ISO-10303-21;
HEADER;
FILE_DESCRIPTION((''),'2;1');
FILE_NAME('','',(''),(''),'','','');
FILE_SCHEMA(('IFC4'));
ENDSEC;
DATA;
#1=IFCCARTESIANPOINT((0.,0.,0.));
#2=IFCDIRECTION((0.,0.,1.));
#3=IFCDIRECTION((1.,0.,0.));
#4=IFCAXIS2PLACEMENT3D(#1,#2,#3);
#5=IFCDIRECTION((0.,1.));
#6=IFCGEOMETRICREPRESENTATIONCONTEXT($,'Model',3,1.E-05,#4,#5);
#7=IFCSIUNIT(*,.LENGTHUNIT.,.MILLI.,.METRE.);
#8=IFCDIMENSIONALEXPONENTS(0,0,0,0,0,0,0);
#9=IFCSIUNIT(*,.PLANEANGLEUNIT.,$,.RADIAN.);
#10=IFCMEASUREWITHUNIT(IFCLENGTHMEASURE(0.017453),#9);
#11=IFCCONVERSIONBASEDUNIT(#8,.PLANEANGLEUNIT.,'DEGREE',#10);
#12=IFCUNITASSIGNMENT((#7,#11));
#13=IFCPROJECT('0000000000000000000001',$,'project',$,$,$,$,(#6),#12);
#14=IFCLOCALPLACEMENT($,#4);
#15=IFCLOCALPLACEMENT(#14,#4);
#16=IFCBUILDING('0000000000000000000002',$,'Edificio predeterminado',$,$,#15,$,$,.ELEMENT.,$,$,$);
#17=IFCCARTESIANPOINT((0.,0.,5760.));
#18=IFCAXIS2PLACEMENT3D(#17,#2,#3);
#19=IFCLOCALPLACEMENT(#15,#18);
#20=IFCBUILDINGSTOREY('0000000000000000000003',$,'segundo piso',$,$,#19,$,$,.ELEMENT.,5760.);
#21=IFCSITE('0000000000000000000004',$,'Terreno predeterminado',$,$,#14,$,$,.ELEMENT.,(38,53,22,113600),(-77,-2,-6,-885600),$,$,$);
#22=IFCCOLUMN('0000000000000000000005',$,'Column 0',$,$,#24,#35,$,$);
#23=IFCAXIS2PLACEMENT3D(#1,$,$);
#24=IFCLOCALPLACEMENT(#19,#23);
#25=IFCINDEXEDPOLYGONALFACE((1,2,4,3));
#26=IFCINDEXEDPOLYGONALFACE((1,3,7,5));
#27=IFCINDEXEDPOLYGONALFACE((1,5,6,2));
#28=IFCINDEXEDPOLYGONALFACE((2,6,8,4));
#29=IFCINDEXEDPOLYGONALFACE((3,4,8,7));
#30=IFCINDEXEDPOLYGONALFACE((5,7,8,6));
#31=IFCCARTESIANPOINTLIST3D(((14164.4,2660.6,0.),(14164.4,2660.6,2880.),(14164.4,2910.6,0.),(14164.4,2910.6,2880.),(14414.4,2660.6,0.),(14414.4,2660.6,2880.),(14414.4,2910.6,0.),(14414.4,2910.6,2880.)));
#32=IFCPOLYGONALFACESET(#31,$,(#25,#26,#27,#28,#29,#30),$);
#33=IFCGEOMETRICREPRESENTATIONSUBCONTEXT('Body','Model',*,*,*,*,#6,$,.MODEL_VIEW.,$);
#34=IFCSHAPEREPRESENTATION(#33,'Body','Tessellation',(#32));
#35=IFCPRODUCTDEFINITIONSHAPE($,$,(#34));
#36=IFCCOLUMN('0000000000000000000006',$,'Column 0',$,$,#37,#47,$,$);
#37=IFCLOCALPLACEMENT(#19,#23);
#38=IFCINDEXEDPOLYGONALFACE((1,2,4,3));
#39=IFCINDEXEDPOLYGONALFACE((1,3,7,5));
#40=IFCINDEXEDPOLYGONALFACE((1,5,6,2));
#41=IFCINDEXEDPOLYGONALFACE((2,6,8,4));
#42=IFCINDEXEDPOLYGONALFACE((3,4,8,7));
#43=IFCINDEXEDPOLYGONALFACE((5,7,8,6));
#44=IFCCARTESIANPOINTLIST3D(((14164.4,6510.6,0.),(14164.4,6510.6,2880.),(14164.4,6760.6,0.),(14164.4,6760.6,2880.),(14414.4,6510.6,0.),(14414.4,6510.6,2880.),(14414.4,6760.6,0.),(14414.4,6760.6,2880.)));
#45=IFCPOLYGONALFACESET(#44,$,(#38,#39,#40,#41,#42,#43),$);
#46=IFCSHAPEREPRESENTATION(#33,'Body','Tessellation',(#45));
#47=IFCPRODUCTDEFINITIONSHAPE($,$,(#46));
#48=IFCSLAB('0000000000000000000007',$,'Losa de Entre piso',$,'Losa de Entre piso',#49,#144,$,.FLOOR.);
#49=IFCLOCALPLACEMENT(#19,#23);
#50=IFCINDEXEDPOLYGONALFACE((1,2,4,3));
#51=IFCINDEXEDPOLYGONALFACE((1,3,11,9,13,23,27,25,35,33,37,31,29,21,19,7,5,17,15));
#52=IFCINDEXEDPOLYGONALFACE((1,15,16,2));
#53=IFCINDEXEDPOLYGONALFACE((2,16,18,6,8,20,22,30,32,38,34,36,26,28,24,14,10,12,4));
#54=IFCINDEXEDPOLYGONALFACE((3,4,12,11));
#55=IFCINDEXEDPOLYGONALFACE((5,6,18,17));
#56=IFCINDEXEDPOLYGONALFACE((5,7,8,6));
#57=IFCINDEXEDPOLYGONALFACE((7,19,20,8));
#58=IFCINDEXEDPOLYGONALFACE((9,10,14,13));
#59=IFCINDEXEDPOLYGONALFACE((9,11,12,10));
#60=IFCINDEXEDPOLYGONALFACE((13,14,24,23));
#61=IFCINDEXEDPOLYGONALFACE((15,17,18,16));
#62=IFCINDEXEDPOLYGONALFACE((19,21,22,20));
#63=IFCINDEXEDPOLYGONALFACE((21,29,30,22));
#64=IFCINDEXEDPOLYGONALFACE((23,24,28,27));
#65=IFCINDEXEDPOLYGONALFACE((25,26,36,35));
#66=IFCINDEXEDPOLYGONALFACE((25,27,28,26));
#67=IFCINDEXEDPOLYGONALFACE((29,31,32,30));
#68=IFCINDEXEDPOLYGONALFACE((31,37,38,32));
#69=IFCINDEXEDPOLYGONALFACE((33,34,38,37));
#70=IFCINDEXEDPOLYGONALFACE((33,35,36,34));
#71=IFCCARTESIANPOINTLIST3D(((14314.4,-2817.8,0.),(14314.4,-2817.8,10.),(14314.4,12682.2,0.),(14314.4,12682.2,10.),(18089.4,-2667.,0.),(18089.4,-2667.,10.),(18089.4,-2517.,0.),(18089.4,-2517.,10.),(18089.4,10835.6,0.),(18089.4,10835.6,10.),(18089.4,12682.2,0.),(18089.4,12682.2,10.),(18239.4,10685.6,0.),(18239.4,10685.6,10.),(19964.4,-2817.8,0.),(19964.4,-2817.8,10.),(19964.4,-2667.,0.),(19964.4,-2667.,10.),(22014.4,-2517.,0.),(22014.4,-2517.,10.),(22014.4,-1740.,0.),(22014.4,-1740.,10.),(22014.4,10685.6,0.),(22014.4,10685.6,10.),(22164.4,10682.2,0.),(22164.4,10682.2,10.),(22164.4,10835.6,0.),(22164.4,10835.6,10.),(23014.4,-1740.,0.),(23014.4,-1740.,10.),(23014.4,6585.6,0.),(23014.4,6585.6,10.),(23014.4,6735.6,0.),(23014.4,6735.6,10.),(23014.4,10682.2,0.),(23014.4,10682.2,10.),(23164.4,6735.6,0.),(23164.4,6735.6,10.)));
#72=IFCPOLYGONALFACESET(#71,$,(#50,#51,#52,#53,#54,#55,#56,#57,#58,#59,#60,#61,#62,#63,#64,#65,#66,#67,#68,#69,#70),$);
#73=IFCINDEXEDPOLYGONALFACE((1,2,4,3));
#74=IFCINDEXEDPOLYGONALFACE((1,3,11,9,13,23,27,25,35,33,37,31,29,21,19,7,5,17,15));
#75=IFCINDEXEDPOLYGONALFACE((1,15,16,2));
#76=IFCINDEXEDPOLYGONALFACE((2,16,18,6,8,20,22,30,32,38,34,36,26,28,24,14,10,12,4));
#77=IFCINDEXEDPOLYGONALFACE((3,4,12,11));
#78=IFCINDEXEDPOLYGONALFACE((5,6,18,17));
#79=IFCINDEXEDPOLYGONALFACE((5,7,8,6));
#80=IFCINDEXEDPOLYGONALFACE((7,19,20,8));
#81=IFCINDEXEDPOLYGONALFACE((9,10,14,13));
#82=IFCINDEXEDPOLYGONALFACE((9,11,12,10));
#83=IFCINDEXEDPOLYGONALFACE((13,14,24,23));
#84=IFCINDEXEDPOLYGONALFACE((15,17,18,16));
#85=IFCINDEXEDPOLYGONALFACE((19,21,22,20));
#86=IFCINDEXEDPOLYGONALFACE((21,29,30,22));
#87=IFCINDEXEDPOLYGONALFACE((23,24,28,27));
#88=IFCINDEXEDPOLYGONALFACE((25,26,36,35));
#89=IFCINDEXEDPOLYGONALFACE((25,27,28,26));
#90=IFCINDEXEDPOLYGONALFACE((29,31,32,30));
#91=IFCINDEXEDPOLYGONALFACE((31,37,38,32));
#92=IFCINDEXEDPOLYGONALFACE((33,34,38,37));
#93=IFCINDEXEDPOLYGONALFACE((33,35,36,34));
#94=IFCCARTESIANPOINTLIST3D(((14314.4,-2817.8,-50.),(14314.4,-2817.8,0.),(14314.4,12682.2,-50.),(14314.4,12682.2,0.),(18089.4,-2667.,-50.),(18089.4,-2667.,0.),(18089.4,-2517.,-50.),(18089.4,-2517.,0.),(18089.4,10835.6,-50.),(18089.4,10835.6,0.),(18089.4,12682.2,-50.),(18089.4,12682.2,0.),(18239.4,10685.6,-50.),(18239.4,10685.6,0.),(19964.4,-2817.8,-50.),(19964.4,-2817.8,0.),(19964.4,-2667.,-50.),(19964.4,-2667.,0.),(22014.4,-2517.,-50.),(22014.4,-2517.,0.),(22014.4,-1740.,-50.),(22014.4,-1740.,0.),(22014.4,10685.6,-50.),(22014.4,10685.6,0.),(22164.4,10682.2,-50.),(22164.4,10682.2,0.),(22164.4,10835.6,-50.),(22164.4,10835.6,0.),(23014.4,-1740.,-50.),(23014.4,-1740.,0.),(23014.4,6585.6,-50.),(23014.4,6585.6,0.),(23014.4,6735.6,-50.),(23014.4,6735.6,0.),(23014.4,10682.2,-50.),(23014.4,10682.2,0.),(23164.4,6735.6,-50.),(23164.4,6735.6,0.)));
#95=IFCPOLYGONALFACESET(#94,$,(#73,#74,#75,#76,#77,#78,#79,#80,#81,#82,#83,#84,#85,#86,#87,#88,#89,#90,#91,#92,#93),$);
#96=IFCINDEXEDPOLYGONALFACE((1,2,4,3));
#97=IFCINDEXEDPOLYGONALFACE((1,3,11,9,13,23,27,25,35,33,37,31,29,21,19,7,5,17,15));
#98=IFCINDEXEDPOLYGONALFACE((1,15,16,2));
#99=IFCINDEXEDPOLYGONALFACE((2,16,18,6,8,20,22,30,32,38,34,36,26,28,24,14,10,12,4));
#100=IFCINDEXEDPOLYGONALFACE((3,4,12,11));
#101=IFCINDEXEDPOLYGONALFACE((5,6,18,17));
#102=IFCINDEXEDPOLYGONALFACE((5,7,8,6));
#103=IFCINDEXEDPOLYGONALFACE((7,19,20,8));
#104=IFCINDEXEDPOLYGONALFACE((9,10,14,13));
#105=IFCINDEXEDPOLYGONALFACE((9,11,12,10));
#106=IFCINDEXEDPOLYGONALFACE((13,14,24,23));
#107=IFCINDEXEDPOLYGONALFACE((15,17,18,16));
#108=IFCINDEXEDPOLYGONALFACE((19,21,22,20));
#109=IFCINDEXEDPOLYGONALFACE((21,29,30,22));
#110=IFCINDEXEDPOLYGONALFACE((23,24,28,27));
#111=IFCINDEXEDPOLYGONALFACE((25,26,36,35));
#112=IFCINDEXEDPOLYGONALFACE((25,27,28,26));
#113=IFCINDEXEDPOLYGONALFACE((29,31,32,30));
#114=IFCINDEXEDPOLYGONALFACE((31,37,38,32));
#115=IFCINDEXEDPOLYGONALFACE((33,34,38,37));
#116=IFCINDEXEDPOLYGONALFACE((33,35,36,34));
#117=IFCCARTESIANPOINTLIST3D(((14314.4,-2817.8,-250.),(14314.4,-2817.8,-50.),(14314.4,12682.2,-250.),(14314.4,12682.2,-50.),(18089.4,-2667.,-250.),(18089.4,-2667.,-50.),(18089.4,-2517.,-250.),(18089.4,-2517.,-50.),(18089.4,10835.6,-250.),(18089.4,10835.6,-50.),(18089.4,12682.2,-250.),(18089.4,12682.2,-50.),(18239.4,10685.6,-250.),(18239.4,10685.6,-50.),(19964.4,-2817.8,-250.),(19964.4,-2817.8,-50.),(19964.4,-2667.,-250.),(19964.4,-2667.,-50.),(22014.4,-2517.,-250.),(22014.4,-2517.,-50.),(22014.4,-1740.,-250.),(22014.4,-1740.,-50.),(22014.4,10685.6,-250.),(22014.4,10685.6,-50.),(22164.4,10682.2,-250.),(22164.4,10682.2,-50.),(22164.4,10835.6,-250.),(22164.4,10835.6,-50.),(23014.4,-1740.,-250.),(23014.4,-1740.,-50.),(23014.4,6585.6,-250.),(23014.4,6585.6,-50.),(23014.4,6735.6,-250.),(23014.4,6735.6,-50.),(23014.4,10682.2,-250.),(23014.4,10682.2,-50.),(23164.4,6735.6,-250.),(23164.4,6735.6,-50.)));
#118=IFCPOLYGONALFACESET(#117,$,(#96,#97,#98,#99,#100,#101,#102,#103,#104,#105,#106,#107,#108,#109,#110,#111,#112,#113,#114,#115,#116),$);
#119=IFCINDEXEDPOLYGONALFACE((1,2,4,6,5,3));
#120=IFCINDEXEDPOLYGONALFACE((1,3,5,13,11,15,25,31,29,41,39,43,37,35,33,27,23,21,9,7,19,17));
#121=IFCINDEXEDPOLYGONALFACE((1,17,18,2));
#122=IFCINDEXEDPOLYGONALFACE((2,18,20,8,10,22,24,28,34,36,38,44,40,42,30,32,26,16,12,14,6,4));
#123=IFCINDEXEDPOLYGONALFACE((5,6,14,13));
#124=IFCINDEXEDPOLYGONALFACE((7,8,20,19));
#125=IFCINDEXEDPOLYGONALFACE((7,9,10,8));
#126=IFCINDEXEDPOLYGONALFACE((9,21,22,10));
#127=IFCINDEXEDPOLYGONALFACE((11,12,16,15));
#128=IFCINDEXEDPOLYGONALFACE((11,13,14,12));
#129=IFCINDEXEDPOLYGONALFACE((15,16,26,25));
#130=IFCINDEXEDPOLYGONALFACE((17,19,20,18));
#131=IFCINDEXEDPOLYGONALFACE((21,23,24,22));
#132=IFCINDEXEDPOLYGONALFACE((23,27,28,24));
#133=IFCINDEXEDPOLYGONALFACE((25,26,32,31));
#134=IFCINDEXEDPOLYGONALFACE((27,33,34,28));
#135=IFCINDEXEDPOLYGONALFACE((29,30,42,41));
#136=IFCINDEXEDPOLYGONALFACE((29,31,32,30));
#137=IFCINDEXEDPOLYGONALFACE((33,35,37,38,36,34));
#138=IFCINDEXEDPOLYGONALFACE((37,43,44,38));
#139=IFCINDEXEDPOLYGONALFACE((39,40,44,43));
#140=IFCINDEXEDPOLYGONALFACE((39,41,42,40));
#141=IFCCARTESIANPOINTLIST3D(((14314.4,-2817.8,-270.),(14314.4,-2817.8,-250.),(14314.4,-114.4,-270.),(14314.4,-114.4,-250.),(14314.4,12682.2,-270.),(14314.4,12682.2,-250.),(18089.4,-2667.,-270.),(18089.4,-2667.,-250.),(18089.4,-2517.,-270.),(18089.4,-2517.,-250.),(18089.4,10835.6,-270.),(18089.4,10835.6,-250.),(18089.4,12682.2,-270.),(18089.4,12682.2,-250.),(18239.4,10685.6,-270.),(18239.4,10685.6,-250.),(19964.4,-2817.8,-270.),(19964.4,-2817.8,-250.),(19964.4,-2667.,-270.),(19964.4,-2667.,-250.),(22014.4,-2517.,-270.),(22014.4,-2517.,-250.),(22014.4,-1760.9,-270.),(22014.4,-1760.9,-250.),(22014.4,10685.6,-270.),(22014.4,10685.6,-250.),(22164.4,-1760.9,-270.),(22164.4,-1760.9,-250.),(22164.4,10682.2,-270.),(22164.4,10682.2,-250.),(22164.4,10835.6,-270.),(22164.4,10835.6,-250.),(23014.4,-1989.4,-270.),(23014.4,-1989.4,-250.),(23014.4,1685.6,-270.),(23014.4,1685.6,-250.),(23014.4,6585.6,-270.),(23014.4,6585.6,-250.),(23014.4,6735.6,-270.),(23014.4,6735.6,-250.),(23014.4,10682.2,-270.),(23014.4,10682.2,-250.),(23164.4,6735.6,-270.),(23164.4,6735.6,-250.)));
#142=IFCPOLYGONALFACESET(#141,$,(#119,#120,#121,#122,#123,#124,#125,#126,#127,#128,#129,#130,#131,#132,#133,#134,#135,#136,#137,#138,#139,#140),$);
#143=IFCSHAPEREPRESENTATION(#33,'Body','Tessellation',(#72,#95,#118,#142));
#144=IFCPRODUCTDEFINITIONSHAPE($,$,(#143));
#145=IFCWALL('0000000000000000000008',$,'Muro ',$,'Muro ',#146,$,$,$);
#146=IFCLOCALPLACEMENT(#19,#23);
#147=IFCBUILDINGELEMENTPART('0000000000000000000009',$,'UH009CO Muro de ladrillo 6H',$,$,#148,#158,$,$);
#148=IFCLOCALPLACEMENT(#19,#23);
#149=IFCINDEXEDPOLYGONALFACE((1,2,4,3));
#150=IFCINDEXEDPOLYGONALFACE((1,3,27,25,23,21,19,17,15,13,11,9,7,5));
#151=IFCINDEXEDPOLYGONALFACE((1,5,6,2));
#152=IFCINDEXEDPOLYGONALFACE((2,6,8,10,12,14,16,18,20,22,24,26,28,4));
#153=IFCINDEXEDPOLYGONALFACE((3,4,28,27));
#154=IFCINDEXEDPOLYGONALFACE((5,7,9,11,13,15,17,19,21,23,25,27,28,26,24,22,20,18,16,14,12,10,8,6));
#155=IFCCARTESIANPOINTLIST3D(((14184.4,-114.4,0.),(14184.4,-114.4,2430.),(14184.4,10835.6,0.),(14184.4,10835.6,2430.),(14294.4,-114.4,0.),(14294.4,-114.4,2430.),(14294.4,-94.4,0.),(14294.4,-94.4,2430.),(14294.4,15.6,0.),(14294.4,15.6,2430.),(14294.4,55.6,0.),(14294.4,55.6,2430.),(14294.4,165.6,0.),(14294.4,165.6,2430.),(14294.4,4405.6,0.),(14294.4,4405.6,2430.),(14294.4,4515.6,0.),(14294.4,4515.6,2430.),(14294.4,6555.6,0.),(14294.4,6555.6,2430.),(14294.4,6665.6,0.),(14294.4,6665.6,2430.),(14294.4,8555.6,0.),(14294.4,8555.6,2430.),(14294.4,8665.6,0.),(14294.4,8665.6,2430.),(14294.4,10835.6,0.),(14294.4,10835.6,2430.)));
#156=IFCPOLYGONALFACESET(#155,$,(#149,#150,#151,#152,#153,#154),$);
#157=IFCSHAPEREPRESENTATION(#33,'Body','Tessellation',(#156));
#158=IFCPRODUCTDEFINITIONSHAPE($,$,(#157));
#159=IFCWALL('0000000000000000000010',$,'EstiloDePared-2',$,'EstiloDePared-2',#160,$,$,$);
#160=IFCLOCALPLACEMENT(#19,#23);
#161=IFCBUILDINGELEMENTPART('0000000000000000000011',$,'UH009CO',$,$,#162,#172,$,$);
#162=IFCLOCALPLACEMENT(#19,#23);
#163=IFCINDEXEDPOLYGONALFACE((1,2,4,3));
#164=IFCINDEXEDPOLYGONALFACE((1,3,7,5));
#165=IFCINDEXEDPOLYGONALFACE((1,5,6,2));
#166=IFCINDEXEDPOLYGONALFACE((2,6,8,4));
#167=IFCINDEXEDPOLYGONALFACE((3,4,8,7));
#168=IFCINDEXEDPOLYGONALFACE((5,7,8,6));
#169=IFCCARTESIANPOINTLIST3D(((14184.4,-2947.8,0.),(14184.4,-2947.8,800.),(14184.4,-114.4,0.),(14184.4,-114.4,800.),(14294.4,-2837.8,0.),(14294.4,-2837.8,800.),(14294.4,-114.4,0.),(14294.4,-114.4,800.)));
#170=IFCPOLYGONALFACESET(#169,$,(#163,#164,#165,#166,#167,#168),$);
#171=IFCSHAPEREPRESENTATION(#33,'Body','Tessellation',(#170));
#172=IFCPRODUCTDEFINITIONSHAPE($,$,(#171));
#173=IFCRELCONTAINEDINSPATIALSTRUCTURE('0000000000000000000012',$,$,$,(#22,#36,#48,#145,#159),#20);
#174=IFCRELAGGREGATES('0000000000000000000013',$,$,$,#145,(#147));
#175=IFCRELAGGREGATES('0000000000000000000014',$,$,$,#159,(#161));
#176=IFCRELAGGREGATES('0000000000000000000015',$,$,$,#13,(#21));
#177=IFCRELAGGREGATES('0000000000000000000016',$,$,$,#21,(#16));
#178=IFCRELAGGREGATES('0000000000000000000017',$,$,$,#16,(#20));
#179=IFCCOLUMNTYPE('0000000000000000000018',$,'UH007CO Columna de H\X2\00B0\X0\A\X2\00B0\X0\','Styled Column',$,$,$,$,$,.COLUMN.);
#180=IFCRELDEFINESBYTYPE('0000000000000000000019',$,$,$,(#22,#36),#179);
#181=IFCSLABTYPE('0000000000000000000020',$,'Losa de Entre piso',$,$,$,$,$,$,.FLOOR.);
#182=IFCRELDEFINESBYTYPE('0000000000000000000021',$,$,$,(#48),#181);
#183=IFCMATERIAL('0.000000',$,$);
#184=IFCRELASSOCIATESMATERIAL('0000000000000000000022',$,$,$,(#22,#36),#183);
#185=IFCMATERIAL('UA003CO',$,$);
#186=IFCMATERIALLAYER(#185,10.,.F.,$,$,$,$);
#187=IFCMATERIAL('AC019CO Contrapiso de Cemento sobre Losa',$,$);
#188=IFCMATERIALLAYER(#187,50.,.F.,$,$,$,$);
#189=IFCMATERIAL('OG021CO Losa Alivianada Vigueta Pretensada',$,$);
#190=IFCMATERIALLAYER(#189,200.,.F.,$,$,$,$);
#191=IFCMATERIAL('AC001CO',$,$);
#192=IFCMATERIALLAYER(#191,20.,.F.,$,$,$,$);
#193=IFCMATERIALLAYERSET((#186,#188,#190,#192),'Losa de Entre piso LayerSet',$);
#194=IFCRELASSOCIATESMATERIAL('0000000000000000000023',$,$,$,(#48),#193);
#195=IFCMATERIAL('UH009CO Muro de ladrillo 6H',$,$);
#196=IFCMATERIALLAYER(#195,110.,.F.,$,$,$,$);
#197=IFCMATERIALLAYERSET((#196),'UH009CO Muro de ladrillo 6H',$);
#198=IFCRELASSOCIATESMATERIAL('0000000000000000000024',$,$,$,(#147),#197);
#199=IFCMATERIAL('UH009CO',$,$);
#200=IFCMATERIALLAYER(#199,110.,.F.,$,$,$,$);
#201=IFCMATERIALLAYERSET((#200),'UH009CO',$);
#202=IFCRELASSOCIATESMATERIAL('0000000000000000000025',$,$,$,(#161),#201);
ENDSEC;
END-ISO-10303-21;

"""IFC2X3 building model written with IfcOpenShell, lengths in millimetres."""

from ifc_helpers import new_model, entity, si_unit, converted_unit, direction, frame, origin_with_axes, place, context, subcontext, project, spatial, polyline, outline, extrude, material, layer, layer_set, layer_usage, type_object, element, aggregate, save


model = new_model("IFC2X3")

# Units and contexts
model_context = context("Model", 3, precision=1e-05, world=origin_with_axes(), true_north=direction((0.0, 1.0)))
body_context = subcontext(model_context, "Body", "Model", "MODEL_VIEW")
ifc_project = project(units=[si_unit("LENGTHUNIT", "METRE", prefix="MILLI"), converted_unit("PLANEANGLEUNIT", "DEGREE", entity("IfcLengthMeasure", 0.017453), si_unit("PLANEANGLEUNIT", "RADIAN"), dimensions=[0, 0, 0, 0, 0, 0, 0])], contexts=[model_context])

# Site, building, storey
site_placement = place(None, origin_with_axes())
site = spatial("IfcSite", under=ifc_project, at=site_placement, Name="Terreno predeterminado", CompositionType="ELEMENT", RefLatitude=(38, 53, 22, 113600), RefLongitude=(-77, -2, -6, -885600))
building_placement = place(site_placement, origin_with_axes())
building = spatial("IfcBuilding", under=site, at=building_placement, Name="Edificio predeterminado", CompositionType="ELEMENT")
storey_placement = place(building_placement, frame((0.0, 0.0, 5760.0), z_axis=(0.0, 0.0, 1.0), x_axis=(1.0, 0.0, 0.0)))
storey = spatial("IfcBuildingStorey", under=building, at=storey_placement, Name="segundo piso", CompositionType="ELEMENT", Elevation=5760.0)

# Columns
ifc_material_1 = material(Name="0.000000")
column_type = type_object("IfcColumnType", Name="UH007CO Columna de H°A°", Description="Styled Column", PredefinedType="COLUMN")
for number, where, z_axis, x_axis, name in (
    (1, (14289.4, 2785.6, 0.0), (0.0, 0.0, 1.0), (1.0, 0.0, 0.0), "Column 0"),
    (2, (14289.4, 6635.6, 0.0), (0.0, 0.0, 1.0), (1.0, 0.0, 0.0), "Column 0"),
):
    element("IfcColumn", number, at=place(storey_placement, frame(where, z_axis=z_axis, x_axis=x_axis)), inside=storey, type_object=column_type, material=ifc_material_1, Name=name, context=body_context, shape_type="SweptSolid", body=[
        extrude(outline(polyline([(-125.0, -125.0), (125.0, -125.0), (125.0, 125.0), (-125.0, 125.0), (-125.0, -125.0)])), origin_with_axes(), (0.0, 0.0, 1.0), 2880.0),
    ])

# Slab
ifc_material_2 = material(Name="UA003CO")
ifc_layer_1 = layer(ifc_material_2, 10.0, ventilated=False)
ifc_material_3 = material(Name="AC019CO Contrapiso de Cemento sobre Losa")
ifc_layer_2 = layer(ifc_material_3, 50.0, ventilated=False)
ifc_material_4 = material(Name="OG021CO Losa Alivianada Vigueta Pretensada")
ifc_layer_3 = layer(ifc_material_4, 200.0, ventilated=False)
ifc_material_5 = material(Name="AC001CO")
ifc_layer_4 = layer(ifc_material_5, 20.0, ventilated=False)
ifc_layer_set_1 = layer_set([ifc_layer_1, ifc_layer_2, ifc_layer_3, ifc_layer_4], Name="Losa de Entre piso LayerSet")
ifc_layer_usage_1 = layer_usage(ifc_layer_set_1, "AXIS3", "POSITIVE", 0.0)
slab_type = type_object("IfcSlabType", Name="Losa de Entre piso", PredefinedType="FLOOR")
slab_placement = place(storey_placement, frame((0.0, 0.0, -5760.0), z_axis=(0.0, 0.0, 1.0), x_axis=(1.0, 0.0, 0.0)))
element("IfcSlab", 3, at=slab_placement, inside=storey, type_object=slab_type, material=ifc_layer_usage_1, Name="Losa de Entre piso", ObjectType="Losa de Entre piso", PredefinedType="FLOOR", context=body_context, shape_type="SweptSolid", body=[
    extrude(outline(polyline([(0.0, -777.0), (-1000.0, -777.0), (-1000.0, -9102.6), (-1150.0, -9252.6), (-1000.0, -9252.6), (-1000.0, -13199.1), (-150.0, -13199.1), (-150.0, -13352.6), (0.0, -13202.6), (3775.0, -13202.6), (3925.0, -13352.6), (3925.0, -15199.1), (7700.0, -15199.1), (7700.0, 300.9), (2050.0, 300.9), (2050.0, 150.0), (3925.0, 150.0), (3925.0, 0.0), (0.0, 0.0), (0.0, -777.0)])), frame((22014.4, -2517.0, 5760.0), z_axis=(0.0, 0.0, 1.0), x_axis=(-1.0, 0.0, 0.0)), (0.0, 0.0, 1.0), 10.0),
    extrude(outline(polyline([(0.0, -777.0), (-1000.0, -777.0), (-1000.0, -9102.6), (-1150.0, -9252.6), (-1000.0, -9252.6), (-1000.0, -13199.1), (-150.0, -13199.1), (-150.0, -13352.6), (0.0, -13202.6), (3775.0, -13202.6), (3925.0, -13352.6), (3925.0, -15199.1), (7700.0, -15199.1), (7700.0, 300.9), (2050.0, 300.9), (2050.0, 150.0), (3925.0, 150.0), (3925.0, 0.0), (0.0, 0.0), (0.0, -777.0)])), frame((22014.4, -2517.0, 5710.0), z_axis=(0.0, 0.0, 1.0), x_axis=(-1.0, 0.0, 0.0)), (0.0, 0.0, 1.0), 50.0),
    extrude(outline(polyline([(0.0, -777.0), (-1000.0, -777.0), (-1000.0, -9102.6), (-1150.0, -9252.6), (-1000.0, -9252.6), (-1000.0, -13199.1), (-150.0, -13199.1), (-150.0, -13352.6), (0.0, -13202.6), (3775.0, -13202.6), (3925.0, -13352.6), (3925.0, -15199.1), (7700.0, -15199.1), (7700.0, 300.9), (2050.0, 300.9), (2050.0, 150.0), (3925.0, 150.0), (3925.0, 0.0), (0.0, 0.0), (0.0, -777.0)])), frame((22014.4, -2517.0, 5510.0), z_axis=(0.0, 0.0, 1.0), x_axis=(-1.0, 0.0, 0.0)), (0.0, 0.0, 1.0), 200.0),
    extrude(outline(polyline([(-1305.7, 1305.7), (-3975.1, -1363.6), (5073.5, -10412.1), (6985.1, -12323.8), (10980.3, -8328.6), (10873.6, -8221.9), (9547.8, -9547.8), (9441.7, -9441.7), (12217.1, -6666.3), (11682.5, -6131.7), (11788.6, -6025.7), (12551.1, -5586.1), (9952.5, -2987.5), (6487.7, 477.3), (6487.7, 689.4), (6381.6, 583.4), (3591.0, 3374.0), (2990.0, 2773.0), (2881.5, 2881.5), (2881.5, 2669.3), (212.1, 0.0), (0.0, 0.0), (-1305.7, 1305.7)])), frame((18089.4, 10835.6, 5490.0), z_axis=(0.0, 0.0, 1.0), x_axis=(0.707107, -0.707107, 0.0)), (0.0, 0.0, 1.0), 20.0),
])

# Walls, building element parts
wall_1_placement = place(storey_placement, frame((14239.4, 10835.6, 0.0), z_axis=(0.0, 0.0, 1.0), x_axis=(0.0, -1.0, 0.0)))
wall_1 = element("IfcWall", 4, at=wall_1_placement, inside=storey, Name="Muro ", ObjectType="Muro ")
ifc_material_6 = material(Name="UH009CO Muro de ladrillo 6H")
ifc_layer_5 = layer(ifc_material_6, 110.0, ventilated=False)
ifc_layer_set_2 = layer_set([ifc_layer_5], Name="UH009CO Muro de ladrillo 6H")
ifc_layer_usage_2 = layer_usage(ifc_layer_set_2, "AXIS2", "NEGATIVE", -55.0)
building_element_part_1_placement = place(wall_1_placement, origin_with_axes())
building_element_part_1 = element("IfcBuildingElementPart", 5, at=building_element_part_1_placement, material=ifc_layer_usage_2, Name="UH009CO Muro de ladrillo 6H", context=body_context, shape_type="SweptSolid", body=[
    extrude(outline(polyline([(4280.0, 55.0), (6320.0, 55.0), (6430.0, 55.0), (10670.0, 55.0), (10780.0, 55.0), (10820.0, 55.0), (10930.0, 55.0), (10950.0, 55.0), (10950.0, -55.0), (0.0, -55.0), (0.0, 55.0), (2170.0, 55.0), (2280.0, 55.0), (4170.0, 55.0), (4280.0, 55.0)])), origin_with_axes(), (0.0, 0.0, 1.0), 2430.0),
])
aggregate(wall_1, [building_element_part_1])
wall_2_placement = place(storey_placement, frame((14239.4, -2892.8, 0.0), z_axis=(0.0, 0.0, 1.0), x_axis=(0.0, 1.0, 0.0)))
wall_2 = element("IfcWall", 6, at=wall_2_placement, inside=storey, Name="EstiloDePared-2", ObjectType="EstiloDePared-2")
ifc_material_7 = material(Name="UH009CO")
ifc_layer_6 = layer(ifc_material_7, 110.0, ventilated=False)
ifc_layer_set_3 = layer_set([ifc_layer_6], Name="UH009CO")
ifc_layer_usage_3 = layer_usage(ifc_layer_set_3, "AXIS2", "NEGATIVE", -55.0)
building_element_part_2_placement = place(wall_2_placement, origin_with_axes())
building_element_part_2 = element("IfcBuildingElementPart", 7, at=building_element_part_2_placement, material=ifc_layer_usage_3, Name="UH009CO", context=body_context, shape_type="SweptSolid", body=[
    extrude(outline(polyline([(2778.4, 55.0), (2778.4, -55.0), (55.0, -55.0), (-55.0, 55.0), (2778.4, 55.0)])), origin_with_axes(), (0.0, 0.0, 1.0), 800.0),
])
aggregate(wall_2, [building_element_part_2])

save(model, "model.ifc")
